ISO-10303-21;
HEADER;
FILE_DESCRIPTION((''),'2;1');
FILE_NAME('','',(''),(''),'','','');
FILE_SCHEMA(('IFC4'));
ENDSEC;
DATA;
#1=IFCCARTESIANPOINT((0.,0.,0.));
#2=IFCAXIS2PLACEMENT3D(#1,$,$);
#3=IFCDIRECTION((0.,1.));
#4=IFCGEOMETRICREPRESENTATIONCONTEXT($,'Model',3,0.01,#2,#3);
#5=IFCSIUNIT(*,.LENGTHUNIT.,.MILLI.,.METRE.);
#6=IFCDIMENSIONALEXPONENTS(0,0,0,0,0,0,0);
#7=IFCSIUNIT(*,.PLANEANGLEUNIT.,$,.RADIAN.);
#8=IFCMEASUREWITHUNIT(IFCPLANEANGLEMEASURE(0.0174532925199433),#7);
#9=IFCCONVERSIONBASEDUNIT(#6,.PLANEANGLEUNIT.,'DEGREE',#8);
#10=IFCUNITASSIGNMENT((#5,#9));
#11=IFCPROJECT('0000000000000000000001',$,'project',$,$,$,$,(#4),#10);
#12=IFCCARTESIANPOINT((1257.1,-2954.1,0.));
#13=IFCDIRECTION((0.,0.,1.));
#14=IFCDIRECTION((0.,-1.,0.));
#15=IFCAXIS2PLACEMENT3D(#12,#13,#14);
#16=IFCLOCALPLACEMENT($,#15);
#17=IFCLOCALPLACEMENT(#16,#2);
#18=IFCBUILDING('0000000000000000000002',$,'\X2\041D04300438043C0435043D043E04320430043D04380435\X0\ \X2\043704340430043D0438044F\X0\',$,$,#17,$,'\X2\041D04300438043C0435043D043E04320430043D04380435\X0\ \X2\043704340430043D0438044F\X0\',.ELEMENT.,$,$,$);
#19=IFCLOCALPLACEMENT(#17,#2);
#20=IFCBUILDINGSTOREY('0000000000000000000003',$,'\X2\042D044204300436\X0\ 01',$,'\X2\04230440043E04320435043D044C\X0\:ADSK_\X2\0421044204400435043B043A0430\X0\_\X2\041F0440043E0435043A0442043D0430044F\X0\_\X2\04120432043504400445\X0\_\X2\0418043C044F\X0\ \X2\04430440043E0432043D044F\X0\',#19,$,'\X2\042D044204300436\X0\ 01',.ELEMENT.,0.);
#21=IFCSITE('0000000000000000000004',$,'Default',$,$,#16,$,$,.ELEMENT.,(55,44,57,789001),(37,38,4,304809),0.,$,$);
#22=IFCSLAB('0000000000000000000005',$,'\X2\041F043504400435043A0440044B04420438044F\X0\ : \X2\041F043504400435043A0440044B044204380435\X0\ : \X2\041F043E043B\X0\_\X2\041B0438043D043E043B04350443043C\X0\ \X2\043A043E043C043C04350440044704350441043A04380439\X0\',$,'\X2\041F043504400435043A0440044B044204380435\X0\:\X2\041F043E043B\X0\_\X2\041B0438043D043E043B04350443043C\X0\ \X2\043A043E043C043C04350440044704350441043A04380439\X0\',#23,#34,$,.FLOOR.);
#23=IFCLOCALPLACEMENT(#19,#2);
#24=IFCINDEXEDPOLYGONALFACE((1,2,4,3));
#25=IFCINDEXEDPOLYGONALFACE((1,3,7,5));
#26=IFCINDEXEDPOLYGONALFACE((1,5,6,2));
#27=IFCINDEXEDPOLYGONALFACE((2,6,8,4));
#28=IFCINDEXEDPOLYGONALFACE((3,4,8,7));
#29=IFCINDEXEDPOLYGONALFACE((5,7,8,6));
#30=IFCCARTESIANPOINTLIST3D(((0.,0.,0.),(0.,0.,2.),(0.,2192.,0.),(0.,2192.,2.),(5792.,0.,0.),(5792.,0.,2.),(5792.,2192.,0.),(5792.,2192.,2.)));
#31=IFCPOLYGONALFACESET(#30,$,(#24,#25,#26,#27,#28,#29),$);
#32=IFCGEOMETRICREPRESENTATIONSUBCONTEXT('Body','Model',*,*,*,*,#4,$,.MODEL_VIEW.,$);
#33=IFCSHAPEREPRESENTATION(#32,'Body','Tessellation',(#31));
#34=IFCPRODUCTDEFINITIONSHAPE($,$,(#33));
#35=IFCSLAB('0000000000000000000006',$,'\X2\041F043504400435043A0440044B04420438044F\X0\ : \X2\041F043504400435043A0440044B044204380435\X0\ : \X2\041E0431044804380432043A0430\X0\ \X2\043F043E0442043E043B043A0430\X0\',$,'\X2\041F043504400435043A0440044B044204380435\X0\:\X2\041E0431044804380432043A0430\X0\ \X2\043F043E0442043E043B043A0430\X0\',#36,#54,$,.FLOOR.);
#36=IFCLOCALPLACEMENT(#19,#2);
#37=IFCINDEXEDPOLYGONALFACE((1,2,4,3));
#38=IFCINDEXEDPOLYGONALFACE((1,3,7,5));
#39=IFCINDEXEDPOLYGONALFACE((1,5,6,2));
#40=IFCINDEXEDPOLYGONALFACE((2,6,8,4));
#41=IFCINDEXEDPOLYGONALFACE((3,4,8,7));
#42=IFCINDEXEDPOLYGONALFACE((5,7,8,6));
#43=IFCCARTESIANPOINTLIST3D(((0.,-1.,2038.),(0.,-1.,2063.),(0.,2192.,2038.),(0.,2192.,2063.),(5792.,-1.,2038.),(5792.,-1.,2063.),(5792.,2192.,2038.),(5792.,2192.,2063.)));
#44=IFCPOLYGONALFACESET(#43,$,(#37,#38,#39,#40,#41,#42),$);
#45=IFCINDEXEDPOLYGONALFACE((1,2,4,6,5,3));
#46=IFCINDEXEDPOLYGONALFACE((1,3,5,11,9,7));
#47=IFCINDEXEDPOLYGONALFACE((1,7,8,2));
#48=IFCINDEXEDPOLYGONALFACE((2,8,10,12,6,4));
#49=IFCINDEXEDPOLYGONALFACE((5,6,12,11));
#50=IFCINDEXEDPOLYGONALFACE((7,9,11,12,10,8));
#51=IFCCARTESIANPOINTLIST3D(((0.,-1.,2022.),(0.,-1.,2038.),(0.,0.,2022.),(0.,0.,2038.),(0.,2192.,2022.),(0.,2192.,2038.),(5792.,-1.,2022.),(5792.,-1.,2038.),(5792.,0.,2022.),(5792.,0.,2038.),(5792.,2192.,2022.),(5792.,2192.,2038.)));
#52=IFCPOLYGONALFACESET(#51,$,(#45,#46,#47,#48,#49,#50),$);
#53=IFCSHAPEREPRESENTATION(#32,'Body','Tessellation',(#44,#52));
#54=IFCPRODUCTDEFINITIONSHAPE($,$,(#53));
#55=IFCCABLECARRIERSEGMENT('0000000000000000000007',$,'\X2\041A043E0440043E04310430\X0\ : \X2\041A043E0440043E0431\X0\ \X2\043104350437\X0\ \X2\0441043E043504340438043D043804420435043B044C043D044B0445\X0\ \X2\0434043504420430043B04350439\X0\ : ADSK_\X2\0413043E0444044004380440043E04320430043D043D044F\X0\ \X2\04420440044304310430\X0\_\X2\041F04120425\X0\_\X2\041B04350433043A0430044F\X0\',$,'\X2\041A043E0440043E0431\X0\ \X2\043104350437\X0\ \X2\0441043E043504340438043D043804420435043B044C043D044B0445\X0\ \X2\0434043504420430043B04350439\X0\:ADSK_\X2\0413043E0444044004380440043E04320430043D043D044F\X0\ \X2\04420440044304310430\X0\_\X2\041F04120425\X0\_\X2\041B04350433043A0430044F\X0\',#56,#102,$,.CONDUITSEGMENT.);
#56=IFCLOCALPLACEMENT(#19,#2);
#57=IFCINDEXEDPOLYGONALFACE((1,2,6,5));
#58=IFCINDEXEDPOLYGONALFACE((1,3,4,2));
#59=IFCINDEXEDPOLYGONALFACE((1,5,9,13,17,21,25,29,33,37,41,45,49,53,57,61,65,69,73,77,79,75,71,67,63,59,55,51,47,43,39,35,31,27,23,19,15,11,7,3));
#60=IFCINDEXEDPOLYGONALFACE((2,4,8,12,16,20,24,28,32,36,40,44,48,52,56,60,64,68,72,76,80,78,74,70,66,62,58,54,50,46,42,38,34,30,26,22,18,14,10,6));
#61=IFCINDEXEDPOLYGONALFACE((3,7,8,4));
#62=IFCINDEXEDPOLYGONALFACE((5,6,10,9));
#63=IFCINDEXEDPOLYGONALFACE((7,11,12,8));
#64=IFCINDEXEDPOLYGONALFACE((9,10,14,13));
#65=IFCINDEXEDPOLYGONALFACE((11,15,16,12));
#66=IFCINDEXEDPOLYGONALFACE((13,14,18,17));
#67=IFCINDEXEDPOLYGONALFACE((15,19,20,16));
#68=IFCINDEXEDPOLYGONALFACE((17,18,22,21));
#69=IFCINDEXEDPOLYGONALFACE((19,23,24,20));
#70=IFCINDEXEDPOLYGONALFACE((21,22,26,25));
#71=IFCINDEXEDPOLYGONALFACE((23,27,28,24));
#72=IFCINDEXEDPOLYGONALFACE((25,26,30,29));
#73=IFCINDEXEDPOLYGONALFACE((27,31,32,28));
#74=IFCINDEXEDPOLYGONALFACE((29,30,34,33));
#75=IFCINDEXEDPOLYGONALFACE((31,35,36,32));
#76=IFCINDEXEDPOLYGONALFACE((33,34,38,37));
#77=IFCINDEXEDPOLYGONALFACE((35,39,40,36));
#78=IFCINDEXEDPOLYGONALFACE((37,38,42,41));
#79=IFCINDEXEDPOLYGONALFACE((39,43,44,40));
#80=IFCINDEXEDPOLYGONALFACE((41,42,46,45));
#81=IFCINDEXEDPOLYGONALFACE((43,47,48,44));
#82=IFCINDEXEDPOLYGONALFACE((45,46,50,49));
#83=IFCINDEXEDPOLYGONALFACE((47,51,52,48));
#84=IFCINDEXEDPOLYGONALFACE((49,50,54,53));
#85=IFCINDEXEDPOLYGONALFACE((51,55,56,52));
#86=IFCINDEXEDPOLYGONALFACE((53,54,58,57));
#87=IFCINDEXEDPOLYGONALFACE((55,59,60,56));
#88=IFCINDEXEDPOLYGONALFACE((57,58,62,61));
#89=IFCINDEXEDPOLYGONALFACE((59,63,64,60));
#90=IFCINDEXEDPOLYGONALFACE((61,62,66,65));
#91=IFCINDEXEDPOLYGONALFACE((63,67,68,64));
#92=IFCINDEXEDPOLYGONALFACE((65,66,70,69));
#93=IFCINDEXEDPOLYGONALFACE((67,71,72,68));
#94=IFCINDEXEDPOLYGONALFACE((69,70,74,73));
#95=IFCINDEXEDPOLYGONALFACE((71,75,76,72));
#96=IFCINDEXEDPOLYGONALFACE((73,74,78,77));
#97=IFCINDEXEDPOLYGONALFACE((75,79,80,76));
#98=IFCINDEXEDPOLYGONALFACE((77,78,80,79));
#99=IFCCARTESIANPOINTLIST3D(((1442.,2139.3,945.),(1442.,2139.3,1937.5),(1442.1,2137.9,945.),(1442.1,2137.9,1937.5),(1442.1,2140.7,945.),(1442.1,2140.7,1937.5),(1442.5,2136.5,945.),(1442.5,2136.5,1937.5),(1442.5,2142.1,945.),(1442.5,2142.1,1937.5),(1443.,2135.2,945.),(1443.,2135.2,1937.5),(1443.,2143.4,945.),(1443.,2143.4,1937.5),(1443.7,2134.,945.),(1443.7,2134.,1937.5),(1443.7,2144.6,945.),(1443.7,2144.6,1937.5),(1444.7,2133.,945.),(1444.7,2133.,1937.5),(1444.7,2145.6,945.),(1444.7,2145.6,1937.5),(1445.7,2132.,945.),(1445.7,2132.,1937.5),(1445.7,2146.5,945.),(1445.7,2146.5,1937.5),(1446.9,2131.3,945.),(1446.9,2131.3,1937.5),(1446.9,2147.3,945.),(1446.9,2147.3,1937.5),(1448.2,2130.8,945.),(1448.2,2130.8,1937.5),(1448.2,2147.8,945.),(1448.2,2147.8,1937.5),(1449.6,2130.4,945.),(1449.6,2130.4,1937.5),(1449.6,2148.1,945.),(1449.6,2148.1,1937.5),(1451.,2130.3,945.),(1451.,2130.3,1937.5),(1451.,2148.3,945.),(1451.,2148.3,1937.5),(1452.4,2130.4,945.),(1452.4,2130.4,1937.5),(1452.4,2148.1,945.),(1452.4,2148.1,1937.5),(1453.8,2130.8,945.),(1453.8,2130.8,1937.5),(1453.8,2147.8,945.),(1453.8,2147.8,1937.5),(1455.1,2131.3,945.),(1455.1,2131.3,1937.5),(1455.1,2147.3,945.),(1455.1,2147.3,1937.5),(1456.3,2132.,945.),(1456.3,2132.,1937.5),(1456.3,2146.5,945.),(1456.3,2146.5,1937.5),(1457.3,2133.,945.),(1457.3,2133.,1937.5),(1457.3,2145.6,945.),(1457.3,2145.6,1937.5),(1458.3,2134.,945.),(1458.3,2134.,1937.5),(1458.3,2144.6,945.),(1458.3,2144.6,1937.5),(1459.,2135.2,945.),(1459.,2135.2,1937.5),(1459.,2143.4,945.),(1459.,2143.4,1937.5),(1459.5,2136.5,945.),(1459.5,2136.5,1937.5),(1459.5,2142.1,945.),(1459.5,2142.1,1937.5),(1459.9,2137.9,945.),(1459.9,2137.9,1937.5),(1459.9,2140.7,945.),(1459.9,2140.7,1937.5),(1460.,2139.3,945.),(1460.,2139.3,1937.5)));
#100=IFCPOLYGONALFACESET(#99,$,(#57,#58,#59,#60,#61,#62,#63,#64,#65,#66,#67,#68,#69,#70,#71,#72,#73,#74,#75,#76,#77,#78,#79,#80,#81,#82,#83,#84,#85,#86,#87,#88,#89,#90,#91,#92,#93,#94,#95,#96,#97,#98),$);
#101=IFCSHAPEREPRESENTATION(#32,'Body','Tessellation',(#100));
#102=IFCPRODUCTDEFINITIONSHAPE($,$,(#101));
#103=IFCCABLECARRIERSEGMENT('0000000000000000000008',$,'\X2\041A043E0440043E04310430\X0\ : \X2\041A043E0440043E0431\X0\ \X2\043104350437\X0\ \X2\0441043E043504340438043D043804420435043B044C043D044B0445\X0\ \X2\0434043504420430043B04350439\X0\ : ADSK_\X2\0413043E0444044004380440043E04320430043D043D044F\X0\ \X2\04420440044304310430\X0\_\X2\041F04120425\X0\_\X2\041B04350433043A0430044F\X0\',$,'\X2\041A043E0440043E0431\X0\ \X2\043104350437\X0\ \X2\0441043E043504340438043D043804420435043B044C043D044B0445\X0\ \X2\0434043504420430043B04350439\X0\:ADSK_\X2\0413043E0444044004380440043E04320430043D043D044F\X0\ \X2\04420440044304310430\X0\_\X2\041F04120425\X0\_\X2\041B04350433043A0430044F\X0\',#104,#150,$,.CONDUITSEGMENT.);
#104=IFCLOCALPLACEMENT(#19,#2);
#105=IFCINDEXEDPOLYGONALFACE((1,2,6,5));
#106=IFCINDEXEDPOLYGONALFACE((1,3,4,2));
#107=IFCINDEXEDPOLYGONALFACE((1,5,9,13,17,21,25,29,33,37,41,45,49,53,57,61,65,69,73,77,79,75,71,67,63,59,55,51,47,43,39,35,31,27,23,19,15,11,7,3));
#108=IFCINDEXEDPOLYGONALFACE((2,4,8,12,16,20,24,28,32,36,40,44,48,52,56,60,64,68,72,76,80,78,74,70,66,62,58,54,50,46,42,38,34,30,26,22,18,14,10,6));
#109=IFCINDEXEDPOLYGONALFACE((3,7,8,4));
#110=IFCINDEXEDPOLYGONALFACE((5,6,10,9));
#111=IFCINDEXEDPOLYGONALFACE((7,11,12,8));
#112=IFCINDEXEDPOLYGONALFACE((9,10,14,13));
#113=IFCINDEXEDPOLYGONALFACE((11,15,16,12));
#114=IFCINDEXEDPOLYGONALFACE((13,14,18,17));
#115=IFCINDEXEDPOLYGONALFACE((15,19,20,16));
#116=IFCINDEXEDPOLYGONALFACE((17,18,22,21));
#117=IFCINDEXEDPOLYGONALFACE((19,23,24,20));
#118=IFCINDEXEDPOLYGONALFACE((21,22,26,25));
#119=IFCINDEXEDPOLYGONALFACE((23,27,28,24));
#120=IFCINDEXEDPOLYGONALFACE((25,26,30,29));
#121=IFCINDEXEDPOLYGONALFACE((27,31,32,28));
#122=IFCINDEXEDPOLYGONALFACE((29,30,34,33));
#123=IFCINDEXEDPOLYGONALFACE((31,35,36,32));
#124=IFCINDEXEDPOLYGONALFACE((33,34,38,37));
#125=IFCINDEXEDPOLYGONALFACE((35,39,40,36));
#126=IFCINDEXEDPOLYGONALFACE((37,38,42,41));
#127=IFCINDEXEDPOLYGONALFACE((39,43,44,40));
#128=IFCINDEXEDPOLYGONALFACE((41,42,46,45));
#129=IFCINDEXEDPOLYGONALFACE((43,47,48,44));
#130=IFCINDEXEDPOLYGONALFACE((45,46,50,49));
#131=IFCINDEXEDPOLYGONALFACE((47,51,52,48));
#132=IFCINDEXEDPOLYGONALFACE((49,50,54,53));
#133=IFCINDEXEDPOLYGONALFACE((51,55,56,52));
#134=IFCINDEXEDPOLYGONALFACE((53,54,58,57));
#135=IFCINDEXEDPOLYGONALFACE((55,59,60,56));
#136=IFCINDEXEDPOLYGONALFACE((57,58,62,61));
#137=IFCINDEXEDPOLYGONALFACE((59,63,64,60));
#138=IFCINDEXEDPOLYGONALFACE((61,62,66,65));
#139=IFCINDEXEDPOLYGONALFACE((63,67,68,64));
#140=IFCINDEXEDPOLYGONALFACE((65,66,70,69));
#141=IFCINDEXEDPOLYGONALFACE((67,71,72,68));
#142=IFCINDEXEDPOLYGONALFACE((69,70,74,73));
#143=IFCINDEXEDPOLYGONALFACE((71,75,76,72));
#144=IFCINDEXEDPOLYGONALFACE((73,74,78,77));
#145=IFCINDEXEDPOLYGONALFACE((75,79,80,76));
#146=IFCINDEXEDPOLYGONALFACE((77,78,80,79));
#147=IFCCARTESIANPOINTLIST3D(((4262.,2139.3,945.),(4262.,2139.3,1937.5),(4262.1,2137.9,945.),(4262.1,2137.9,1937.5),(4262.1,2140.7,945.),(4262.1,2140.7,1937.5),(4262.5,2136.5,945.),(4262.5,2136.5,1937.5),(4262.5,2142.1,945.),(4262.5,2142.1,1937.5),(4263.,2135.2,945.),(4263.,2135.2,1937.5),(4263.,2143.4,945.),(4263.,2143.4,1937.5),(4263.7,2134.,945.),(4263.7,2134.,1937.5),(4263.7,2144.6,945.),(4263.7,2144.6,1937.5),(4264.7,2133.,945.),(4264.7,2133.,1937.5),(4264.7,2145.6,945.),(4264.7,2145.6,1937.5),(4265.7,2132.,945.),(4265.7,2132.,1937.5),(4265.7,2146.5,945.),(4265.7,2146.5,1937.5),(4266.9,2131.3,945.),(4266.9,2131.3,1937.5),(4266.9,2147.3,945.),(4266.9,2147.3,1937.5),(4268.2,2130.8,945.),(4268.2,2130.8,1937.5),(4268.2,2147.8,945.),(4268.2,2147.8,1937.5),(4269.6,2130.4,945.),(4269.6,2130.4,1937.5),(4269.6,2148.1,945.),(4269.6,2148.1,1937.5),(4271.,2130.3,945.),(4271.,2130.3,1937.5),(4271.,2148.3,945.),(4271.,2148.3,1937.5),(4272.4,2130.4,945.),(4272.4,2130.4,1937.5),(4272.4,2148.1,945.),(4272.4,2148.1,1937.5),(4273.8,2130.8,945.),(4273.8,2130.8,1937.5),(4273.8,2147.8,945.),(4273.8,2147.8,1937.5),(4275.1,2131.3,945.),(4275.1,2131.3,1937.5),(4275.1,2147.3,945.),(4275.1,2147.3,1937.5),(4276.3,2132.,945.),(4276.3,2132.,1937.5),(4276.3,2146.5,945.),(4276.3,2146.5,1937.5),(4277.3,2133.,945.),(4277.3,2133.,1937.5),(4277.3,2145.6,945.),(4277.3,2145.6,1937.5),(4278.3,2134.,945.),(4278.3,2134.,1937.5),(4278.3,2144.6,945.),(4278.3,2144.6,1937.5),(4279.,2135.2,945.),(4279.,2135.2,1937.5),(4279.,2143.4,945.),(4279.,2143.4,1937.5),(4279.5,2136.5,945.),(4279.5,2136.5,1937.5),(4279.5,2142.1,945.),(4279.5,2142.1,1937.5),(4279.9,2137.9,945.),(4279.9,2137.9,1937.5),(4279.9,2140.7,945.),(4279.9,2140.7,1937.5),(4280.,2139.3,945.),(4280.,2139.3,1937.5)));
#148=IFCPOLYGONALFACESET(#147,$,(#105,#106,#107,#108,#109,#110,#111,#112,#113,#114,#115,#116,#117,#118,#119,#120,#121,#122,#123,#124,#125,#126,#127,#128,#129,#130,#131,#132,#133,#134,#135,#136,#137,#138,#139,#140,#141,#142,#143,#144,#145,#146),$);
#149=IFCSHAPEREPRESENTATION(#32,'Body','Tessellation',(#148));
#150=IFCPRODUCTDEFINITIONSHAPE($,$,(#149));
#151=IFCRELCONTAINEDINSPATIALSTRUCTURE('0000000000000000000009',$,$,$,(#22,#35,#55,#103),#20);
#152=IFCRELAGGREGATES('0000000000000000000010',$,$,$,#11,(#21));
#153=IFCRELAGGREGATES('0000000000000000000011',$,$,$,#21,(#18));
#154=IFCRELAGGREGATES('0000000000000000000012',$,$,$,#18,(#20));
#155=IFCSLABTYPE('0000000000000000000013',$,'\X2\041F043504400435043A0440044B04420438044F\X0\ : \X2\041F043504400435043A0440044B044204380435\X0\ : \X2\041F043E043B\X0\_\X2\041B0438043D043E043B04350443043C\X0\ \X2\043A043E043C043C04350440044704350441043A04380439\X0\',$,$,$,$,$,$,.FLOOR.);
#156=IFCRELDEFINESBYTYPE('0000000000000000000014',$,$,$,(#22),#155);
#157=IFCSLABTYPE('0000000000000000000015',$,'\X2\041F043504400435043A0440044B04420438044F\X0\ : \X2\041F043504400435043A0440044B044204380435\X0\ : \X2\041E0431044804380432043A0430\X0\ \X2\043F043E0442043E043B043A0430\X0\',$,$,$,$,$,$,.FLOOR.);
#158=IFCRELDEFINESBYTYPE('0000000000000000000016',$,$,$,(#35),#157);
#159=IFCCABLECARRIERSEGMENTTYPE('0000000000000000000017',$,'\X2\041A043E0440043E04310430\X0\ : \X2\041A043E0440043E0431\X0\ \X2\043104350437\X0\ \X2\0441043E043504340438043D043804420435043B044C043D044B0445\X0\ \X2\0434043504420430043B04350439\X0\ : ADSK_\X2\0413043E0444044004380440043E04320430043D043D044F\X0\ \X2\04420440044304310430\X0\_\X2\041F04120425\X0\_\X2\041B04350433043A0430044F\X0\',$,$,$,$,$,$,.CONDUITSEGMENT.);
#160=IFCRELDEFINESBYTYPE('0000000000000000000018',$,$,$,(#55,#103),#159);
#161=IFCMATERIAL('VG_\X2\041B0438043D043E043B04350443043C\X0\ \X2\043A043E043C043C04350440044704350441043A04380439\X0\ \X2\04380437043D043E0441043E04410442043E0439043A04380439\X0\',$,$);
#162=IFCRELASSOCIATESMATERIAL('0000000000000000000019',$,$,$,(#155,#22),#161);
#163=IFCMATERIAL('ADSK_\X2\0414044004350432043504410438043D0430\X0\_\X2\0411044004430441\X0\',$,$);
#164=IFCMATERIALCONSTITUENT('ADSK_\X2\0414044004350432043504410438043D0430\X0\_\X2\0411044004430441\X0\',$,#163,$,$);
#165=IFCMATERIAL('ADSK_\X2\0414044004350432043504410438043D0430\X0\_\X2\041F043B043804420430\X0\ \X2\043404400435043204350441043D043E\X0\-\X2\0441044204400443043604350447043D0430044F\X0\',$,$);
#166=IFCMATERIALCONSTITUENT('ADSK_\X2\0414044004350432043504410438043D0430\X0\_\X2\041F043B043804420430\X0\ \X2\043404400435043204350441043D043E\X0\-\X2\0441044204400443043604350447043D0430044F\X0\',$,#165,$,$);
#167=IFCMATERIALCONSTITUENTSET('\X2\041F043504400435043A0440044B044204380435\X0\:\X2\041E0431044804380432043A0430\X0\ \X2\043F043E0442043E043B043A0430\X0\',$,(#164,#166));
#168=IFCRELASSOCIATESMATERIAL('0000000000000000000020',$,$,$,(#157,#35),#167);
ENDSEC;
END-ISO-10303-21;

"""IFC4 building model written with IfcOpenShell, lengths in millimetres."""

from ifc_helpers import new_model, entity, si_unit, converted_unit, direction, frame, origin, place, context, subcontext, project, spatial, indexed_curve, outline, extrude, material, constituent, constituent_set, type_object, element, save


model = new_model("IFC4")

# Units and contexts
model_context = context("Model", 3, precision=0.01, world=origin(), true_north=direction((0.0, 1.0)))
body_context = subcontext(model_context, "Body", "Model", "MODEL_VIEW")
ifc_project = project(units=[si_unit("LENGTHUNIT", "METRE", prefix="MILLI"), converted_unit("PLANEANGLEUNIT", "DEGREE", entity("IfcPlaneAngleMeasure", 0.0174532925199433), si_unit("PLANEANGLEUNIT", "RADIAN"), dimensions=[0, 0, 0, 0, 0, 0, 0])], contexts=[model_context])

# Site, building, storey
site_placement = place(None, frame((1257.1, -2954.1, 0.0), z_axis=(0.0, 0.0, 1.0), x_axis=(0.0, -1.0, 0.0)))
site = spatial("IfcSite", under=ifc_project, at=site_placement, Name="Default", CompositionType="ELEMENT", RefLatitude=(55, 44, 57, 789001), RefLongitude=(37, 38, 4, 304809), RefElevation=0.0)
building_placement = place(site_placement, origin())
building = spatial("IfcBuilding", under=site, at=building_placement, Name="Наименование здания", LongName="Наименование здания", CompositionType="ELEMENT")
storey_placement = place(building_placement, origin())
storey = spatial("IfcBuildingStorey", under=building, at=storey_placement, Name="Этаж 01", ObjectType="Уровень:ADSK_Стрелка_Проектная_Вверх_Имя уровня", LongName="Этаж 01", CompositionType="ELEMENT", Elevation=0.0)

# Slabs
ifc_material_1 = material(Name="VG_Линолеум коммерческий износостойкий")
slab_type_1 = type_object("IfcSlabType", Name="Перекрытия : Перекрытие : Пол_Линолеум коммерческий", PredefinedType="FLOOR", material=ifc_material_1)
slab_1_placement = place(storey_placement, origin())
element("IfcSlab", 1, at=slab_1_placement, inside=storey, type_object=slab_type_1, material=ifc_material_1, Name="Перекрытия : Перекрытие : Пол_Линолеум коммерческий", ObjectType="Перекрытие:Пол_Линолеум коммерческий", PredefinedType="FLOOR", context=body_context, shape_type="SweptSolid", body=[
    extrude(outline(indexed_curve([(-1096.0, -2896.0), (1096.0, -2896.0), (1096.0, 2896.0), (-1096.0, 2896.0), (-1096.0, -2896.0)], self_intersect=False)), frame((2896.0, 1096.0, 2.0), z_axis=(0.0, 0.0, -1.0), x_axis=(0.0, 1.0, 0.0)), (0.0, 0.0, 1.0), 2.0),
])
ifc_material_2 = material(Name="ADSK_Древесина_Брус")
ifc_constituent_1 = constituent(ifc_material_2, Name="ADSK_Древесина_Брус")
ifc_material_3 = material(Name="ADSK_Древесина_Плита древесно-стружечная")
ifc_constituent_2 = constituent(ifc_material_3, Name="ADSK_Древесина_Плита древесно-стружечная")
ifc_constituent_set_1 = constituent_set(constituents=[ifc_constituent_1, ifc_constituent_2], Name="Перекрытие:Обшивка потолка")
slab_type_2 = type_object("IfcSlabType", Name="Перекрытия : Перекрытие : Обшивка потолка", PredefinedType="FLOOR", material=ifc_constituent_set_1)
slab_2_placement = place(storey_placement, origin())
element("IfcSlab", 2, at=slab_2_placement, inside=storey, type_object=slab_type_2, material=ifc_constituent_set_1, Name="Перекрытия : Перекрытие : Обшивка потолка", ObjectType="Перекрытие:Обшивка потолка", PredefinedType="FLOOR", context=body_context, shape_type="SweptSolid", body=[
    extrude(outline(indexed_curve([(-2896.0, -1096.5), (2896.0, -1096.5), (2896.0, 1096.5), (-2896.0, 1096.5), (-2896.0, -1096.5)], self_intersect=False)), frame((2896.0, 1095.5, 2038.0), z_axis=(0.0, 0.0, 1.0), x_axis=(-1.0, 0.0, 0.0)), (0.0, 0.0, 1.0), 25.0),
    extrude(outline(indexed_curve([(-2896.0, -1461.7), (2896.0, -1461.7), (2896.0, 730.3), (2896.0, 731.3), (-2896.0, 731.3), (-2896.0, 730.3), (-2896.0, -1461.7)], self_intersect=False)), frame((2896.0, 730.3, 2022.0), z_axis=(0.0, 0.0, 1.0), x_axis=(-1.0, 0.0, 0.0)), (0.0, 0.0, 1.0), 16.0),
])

# Cable carrier segments
cable_carrier_segment_type = type_object("IfcCableCarrierSegmentType", Name="Короба : Короб без соединительных деталей : ADSK_Гофрировання труба_ПВХ_Легкая", PredefinedType="CONDUITSEGMENT")
cable_carrier_segment_1_placement = place(storey_placement, origin())
element("IfcCableCarrierSegment", 3, at=cable_carrier_segment_1_placement, inside=storey, type_object=cable_carrier_segment_type, Name="Короба : Короб без соединительных деталей : ADSK_Гофрировання труба_ПВХ_Легкая", ObjectType="Короб без соединительных деталей:ADSK_Гофрировання труба_ПВХ_Легкая", PredefinedType="CONDUITSEGMENT", context=body_context, shape_type="SweptSolid", body=[
    extrude(outline(indexed_curve([(9.0, 0.0), (8.9, 1.4), (8.5, 2.8), (8.0, 4.1), (7.3, 5.3), (6.3, 6.3), (5.3, 7.3), (4.1, 8.0), (2.8, 8.5), (1.4, 8.9), (0.0, 9.0), (-1.4, 8.9), (-2.8, 8.5), (-4.1, 8.0), (-5.3, 7.3), (-6.3, 6.3), (-7.3, 5.3), (-8.0, 4.1), (-8.5, 2.8), (-8.9, 1.4), (-9.0, 0.0), (-8.9, -1.4), (-8.5, -2.8), (-8.0, -4.1), (-7.3, -5.3), (-6.3, -6.3), (-5.3, -7.3), (-4.1, -8.0), (-2.8, -8.5), (-1.4, -8.9), (0.0, -9.0), (1.4, -8.9), (2.8, -8.5), (4.1, -8.0), (5.3, -7.3), (6.3, -6.3), (7.3, -5.3), (8.0, -4.1), (8.5, -2.8), (8.9, -1.4), (9.0, 0.0)], self_intersect=False)), frame((1451.0, 2139.3, 945.0)), (0.0, 0.0, 1.0), 992.5),
])
cable_carrier_segment_2_placement = place(storey_placement, origin())
element("IfcCableCarrierSegment", 4, at=cable_carrier_segment_2_placement, inside=storey, type_object=cable_carrier_segment_type, Name="Короба : Короб без соединительных деталей : ADSK_Гофрировання труба_ПВХ_Легкая", ObjectType="Короб без соединительных деталей:ADSK_Гофрировання труба_ПВХ_Легкая", PredefinedType="CONDUITSEGMENT", context=body_context, shape_type="SweptSolid", body=[
    extrude(outline(indexed_curve([(9.0, 0.0), (8.9, 1.4), (8.5, 2.8), (8.0, 4.1), (7.3, 5.3), (6.3, 6.3), (5.3, 7.3), (4.1, 8.0), (2.8, 8.5), (1.4, 8.9), (0.0, 9.0), (-1.4, 8.9), (-2.8, 8.5), (-4.1, 8.0), (-5.3, 7.3), (-6.3, 6.3), (-7.3, 5.3), (-8.0, 4.1), (-8.5, 2.8), (-8.9, 1.4), (-9.0, 0.0), (-8.9, -1.4), (-8.5, -2.8), (-8.0, -4.1), (-7.3, -5.3), (-6.3, -6.3), (-5.3, -7.3), (-4.1, -8.0), (-2.8, -8.5), (-1.4, -8.9), (0.0, -9.0), (1.4, -8.9), (2.8, -8.5), (4.1, -8.0), (5.3, -7.3), (6.3, -6.3), (7.3, -5.3), (8.0, -4.1), (8.5, -2.8), (8.9, -1.4), (9.0, 0.0)], self_intersect=False)), frame((4271.0, 2139.3, 945.0)), (0.0, 0.0, 1.0), 992.5),
])

save(model, "model.ifc")
